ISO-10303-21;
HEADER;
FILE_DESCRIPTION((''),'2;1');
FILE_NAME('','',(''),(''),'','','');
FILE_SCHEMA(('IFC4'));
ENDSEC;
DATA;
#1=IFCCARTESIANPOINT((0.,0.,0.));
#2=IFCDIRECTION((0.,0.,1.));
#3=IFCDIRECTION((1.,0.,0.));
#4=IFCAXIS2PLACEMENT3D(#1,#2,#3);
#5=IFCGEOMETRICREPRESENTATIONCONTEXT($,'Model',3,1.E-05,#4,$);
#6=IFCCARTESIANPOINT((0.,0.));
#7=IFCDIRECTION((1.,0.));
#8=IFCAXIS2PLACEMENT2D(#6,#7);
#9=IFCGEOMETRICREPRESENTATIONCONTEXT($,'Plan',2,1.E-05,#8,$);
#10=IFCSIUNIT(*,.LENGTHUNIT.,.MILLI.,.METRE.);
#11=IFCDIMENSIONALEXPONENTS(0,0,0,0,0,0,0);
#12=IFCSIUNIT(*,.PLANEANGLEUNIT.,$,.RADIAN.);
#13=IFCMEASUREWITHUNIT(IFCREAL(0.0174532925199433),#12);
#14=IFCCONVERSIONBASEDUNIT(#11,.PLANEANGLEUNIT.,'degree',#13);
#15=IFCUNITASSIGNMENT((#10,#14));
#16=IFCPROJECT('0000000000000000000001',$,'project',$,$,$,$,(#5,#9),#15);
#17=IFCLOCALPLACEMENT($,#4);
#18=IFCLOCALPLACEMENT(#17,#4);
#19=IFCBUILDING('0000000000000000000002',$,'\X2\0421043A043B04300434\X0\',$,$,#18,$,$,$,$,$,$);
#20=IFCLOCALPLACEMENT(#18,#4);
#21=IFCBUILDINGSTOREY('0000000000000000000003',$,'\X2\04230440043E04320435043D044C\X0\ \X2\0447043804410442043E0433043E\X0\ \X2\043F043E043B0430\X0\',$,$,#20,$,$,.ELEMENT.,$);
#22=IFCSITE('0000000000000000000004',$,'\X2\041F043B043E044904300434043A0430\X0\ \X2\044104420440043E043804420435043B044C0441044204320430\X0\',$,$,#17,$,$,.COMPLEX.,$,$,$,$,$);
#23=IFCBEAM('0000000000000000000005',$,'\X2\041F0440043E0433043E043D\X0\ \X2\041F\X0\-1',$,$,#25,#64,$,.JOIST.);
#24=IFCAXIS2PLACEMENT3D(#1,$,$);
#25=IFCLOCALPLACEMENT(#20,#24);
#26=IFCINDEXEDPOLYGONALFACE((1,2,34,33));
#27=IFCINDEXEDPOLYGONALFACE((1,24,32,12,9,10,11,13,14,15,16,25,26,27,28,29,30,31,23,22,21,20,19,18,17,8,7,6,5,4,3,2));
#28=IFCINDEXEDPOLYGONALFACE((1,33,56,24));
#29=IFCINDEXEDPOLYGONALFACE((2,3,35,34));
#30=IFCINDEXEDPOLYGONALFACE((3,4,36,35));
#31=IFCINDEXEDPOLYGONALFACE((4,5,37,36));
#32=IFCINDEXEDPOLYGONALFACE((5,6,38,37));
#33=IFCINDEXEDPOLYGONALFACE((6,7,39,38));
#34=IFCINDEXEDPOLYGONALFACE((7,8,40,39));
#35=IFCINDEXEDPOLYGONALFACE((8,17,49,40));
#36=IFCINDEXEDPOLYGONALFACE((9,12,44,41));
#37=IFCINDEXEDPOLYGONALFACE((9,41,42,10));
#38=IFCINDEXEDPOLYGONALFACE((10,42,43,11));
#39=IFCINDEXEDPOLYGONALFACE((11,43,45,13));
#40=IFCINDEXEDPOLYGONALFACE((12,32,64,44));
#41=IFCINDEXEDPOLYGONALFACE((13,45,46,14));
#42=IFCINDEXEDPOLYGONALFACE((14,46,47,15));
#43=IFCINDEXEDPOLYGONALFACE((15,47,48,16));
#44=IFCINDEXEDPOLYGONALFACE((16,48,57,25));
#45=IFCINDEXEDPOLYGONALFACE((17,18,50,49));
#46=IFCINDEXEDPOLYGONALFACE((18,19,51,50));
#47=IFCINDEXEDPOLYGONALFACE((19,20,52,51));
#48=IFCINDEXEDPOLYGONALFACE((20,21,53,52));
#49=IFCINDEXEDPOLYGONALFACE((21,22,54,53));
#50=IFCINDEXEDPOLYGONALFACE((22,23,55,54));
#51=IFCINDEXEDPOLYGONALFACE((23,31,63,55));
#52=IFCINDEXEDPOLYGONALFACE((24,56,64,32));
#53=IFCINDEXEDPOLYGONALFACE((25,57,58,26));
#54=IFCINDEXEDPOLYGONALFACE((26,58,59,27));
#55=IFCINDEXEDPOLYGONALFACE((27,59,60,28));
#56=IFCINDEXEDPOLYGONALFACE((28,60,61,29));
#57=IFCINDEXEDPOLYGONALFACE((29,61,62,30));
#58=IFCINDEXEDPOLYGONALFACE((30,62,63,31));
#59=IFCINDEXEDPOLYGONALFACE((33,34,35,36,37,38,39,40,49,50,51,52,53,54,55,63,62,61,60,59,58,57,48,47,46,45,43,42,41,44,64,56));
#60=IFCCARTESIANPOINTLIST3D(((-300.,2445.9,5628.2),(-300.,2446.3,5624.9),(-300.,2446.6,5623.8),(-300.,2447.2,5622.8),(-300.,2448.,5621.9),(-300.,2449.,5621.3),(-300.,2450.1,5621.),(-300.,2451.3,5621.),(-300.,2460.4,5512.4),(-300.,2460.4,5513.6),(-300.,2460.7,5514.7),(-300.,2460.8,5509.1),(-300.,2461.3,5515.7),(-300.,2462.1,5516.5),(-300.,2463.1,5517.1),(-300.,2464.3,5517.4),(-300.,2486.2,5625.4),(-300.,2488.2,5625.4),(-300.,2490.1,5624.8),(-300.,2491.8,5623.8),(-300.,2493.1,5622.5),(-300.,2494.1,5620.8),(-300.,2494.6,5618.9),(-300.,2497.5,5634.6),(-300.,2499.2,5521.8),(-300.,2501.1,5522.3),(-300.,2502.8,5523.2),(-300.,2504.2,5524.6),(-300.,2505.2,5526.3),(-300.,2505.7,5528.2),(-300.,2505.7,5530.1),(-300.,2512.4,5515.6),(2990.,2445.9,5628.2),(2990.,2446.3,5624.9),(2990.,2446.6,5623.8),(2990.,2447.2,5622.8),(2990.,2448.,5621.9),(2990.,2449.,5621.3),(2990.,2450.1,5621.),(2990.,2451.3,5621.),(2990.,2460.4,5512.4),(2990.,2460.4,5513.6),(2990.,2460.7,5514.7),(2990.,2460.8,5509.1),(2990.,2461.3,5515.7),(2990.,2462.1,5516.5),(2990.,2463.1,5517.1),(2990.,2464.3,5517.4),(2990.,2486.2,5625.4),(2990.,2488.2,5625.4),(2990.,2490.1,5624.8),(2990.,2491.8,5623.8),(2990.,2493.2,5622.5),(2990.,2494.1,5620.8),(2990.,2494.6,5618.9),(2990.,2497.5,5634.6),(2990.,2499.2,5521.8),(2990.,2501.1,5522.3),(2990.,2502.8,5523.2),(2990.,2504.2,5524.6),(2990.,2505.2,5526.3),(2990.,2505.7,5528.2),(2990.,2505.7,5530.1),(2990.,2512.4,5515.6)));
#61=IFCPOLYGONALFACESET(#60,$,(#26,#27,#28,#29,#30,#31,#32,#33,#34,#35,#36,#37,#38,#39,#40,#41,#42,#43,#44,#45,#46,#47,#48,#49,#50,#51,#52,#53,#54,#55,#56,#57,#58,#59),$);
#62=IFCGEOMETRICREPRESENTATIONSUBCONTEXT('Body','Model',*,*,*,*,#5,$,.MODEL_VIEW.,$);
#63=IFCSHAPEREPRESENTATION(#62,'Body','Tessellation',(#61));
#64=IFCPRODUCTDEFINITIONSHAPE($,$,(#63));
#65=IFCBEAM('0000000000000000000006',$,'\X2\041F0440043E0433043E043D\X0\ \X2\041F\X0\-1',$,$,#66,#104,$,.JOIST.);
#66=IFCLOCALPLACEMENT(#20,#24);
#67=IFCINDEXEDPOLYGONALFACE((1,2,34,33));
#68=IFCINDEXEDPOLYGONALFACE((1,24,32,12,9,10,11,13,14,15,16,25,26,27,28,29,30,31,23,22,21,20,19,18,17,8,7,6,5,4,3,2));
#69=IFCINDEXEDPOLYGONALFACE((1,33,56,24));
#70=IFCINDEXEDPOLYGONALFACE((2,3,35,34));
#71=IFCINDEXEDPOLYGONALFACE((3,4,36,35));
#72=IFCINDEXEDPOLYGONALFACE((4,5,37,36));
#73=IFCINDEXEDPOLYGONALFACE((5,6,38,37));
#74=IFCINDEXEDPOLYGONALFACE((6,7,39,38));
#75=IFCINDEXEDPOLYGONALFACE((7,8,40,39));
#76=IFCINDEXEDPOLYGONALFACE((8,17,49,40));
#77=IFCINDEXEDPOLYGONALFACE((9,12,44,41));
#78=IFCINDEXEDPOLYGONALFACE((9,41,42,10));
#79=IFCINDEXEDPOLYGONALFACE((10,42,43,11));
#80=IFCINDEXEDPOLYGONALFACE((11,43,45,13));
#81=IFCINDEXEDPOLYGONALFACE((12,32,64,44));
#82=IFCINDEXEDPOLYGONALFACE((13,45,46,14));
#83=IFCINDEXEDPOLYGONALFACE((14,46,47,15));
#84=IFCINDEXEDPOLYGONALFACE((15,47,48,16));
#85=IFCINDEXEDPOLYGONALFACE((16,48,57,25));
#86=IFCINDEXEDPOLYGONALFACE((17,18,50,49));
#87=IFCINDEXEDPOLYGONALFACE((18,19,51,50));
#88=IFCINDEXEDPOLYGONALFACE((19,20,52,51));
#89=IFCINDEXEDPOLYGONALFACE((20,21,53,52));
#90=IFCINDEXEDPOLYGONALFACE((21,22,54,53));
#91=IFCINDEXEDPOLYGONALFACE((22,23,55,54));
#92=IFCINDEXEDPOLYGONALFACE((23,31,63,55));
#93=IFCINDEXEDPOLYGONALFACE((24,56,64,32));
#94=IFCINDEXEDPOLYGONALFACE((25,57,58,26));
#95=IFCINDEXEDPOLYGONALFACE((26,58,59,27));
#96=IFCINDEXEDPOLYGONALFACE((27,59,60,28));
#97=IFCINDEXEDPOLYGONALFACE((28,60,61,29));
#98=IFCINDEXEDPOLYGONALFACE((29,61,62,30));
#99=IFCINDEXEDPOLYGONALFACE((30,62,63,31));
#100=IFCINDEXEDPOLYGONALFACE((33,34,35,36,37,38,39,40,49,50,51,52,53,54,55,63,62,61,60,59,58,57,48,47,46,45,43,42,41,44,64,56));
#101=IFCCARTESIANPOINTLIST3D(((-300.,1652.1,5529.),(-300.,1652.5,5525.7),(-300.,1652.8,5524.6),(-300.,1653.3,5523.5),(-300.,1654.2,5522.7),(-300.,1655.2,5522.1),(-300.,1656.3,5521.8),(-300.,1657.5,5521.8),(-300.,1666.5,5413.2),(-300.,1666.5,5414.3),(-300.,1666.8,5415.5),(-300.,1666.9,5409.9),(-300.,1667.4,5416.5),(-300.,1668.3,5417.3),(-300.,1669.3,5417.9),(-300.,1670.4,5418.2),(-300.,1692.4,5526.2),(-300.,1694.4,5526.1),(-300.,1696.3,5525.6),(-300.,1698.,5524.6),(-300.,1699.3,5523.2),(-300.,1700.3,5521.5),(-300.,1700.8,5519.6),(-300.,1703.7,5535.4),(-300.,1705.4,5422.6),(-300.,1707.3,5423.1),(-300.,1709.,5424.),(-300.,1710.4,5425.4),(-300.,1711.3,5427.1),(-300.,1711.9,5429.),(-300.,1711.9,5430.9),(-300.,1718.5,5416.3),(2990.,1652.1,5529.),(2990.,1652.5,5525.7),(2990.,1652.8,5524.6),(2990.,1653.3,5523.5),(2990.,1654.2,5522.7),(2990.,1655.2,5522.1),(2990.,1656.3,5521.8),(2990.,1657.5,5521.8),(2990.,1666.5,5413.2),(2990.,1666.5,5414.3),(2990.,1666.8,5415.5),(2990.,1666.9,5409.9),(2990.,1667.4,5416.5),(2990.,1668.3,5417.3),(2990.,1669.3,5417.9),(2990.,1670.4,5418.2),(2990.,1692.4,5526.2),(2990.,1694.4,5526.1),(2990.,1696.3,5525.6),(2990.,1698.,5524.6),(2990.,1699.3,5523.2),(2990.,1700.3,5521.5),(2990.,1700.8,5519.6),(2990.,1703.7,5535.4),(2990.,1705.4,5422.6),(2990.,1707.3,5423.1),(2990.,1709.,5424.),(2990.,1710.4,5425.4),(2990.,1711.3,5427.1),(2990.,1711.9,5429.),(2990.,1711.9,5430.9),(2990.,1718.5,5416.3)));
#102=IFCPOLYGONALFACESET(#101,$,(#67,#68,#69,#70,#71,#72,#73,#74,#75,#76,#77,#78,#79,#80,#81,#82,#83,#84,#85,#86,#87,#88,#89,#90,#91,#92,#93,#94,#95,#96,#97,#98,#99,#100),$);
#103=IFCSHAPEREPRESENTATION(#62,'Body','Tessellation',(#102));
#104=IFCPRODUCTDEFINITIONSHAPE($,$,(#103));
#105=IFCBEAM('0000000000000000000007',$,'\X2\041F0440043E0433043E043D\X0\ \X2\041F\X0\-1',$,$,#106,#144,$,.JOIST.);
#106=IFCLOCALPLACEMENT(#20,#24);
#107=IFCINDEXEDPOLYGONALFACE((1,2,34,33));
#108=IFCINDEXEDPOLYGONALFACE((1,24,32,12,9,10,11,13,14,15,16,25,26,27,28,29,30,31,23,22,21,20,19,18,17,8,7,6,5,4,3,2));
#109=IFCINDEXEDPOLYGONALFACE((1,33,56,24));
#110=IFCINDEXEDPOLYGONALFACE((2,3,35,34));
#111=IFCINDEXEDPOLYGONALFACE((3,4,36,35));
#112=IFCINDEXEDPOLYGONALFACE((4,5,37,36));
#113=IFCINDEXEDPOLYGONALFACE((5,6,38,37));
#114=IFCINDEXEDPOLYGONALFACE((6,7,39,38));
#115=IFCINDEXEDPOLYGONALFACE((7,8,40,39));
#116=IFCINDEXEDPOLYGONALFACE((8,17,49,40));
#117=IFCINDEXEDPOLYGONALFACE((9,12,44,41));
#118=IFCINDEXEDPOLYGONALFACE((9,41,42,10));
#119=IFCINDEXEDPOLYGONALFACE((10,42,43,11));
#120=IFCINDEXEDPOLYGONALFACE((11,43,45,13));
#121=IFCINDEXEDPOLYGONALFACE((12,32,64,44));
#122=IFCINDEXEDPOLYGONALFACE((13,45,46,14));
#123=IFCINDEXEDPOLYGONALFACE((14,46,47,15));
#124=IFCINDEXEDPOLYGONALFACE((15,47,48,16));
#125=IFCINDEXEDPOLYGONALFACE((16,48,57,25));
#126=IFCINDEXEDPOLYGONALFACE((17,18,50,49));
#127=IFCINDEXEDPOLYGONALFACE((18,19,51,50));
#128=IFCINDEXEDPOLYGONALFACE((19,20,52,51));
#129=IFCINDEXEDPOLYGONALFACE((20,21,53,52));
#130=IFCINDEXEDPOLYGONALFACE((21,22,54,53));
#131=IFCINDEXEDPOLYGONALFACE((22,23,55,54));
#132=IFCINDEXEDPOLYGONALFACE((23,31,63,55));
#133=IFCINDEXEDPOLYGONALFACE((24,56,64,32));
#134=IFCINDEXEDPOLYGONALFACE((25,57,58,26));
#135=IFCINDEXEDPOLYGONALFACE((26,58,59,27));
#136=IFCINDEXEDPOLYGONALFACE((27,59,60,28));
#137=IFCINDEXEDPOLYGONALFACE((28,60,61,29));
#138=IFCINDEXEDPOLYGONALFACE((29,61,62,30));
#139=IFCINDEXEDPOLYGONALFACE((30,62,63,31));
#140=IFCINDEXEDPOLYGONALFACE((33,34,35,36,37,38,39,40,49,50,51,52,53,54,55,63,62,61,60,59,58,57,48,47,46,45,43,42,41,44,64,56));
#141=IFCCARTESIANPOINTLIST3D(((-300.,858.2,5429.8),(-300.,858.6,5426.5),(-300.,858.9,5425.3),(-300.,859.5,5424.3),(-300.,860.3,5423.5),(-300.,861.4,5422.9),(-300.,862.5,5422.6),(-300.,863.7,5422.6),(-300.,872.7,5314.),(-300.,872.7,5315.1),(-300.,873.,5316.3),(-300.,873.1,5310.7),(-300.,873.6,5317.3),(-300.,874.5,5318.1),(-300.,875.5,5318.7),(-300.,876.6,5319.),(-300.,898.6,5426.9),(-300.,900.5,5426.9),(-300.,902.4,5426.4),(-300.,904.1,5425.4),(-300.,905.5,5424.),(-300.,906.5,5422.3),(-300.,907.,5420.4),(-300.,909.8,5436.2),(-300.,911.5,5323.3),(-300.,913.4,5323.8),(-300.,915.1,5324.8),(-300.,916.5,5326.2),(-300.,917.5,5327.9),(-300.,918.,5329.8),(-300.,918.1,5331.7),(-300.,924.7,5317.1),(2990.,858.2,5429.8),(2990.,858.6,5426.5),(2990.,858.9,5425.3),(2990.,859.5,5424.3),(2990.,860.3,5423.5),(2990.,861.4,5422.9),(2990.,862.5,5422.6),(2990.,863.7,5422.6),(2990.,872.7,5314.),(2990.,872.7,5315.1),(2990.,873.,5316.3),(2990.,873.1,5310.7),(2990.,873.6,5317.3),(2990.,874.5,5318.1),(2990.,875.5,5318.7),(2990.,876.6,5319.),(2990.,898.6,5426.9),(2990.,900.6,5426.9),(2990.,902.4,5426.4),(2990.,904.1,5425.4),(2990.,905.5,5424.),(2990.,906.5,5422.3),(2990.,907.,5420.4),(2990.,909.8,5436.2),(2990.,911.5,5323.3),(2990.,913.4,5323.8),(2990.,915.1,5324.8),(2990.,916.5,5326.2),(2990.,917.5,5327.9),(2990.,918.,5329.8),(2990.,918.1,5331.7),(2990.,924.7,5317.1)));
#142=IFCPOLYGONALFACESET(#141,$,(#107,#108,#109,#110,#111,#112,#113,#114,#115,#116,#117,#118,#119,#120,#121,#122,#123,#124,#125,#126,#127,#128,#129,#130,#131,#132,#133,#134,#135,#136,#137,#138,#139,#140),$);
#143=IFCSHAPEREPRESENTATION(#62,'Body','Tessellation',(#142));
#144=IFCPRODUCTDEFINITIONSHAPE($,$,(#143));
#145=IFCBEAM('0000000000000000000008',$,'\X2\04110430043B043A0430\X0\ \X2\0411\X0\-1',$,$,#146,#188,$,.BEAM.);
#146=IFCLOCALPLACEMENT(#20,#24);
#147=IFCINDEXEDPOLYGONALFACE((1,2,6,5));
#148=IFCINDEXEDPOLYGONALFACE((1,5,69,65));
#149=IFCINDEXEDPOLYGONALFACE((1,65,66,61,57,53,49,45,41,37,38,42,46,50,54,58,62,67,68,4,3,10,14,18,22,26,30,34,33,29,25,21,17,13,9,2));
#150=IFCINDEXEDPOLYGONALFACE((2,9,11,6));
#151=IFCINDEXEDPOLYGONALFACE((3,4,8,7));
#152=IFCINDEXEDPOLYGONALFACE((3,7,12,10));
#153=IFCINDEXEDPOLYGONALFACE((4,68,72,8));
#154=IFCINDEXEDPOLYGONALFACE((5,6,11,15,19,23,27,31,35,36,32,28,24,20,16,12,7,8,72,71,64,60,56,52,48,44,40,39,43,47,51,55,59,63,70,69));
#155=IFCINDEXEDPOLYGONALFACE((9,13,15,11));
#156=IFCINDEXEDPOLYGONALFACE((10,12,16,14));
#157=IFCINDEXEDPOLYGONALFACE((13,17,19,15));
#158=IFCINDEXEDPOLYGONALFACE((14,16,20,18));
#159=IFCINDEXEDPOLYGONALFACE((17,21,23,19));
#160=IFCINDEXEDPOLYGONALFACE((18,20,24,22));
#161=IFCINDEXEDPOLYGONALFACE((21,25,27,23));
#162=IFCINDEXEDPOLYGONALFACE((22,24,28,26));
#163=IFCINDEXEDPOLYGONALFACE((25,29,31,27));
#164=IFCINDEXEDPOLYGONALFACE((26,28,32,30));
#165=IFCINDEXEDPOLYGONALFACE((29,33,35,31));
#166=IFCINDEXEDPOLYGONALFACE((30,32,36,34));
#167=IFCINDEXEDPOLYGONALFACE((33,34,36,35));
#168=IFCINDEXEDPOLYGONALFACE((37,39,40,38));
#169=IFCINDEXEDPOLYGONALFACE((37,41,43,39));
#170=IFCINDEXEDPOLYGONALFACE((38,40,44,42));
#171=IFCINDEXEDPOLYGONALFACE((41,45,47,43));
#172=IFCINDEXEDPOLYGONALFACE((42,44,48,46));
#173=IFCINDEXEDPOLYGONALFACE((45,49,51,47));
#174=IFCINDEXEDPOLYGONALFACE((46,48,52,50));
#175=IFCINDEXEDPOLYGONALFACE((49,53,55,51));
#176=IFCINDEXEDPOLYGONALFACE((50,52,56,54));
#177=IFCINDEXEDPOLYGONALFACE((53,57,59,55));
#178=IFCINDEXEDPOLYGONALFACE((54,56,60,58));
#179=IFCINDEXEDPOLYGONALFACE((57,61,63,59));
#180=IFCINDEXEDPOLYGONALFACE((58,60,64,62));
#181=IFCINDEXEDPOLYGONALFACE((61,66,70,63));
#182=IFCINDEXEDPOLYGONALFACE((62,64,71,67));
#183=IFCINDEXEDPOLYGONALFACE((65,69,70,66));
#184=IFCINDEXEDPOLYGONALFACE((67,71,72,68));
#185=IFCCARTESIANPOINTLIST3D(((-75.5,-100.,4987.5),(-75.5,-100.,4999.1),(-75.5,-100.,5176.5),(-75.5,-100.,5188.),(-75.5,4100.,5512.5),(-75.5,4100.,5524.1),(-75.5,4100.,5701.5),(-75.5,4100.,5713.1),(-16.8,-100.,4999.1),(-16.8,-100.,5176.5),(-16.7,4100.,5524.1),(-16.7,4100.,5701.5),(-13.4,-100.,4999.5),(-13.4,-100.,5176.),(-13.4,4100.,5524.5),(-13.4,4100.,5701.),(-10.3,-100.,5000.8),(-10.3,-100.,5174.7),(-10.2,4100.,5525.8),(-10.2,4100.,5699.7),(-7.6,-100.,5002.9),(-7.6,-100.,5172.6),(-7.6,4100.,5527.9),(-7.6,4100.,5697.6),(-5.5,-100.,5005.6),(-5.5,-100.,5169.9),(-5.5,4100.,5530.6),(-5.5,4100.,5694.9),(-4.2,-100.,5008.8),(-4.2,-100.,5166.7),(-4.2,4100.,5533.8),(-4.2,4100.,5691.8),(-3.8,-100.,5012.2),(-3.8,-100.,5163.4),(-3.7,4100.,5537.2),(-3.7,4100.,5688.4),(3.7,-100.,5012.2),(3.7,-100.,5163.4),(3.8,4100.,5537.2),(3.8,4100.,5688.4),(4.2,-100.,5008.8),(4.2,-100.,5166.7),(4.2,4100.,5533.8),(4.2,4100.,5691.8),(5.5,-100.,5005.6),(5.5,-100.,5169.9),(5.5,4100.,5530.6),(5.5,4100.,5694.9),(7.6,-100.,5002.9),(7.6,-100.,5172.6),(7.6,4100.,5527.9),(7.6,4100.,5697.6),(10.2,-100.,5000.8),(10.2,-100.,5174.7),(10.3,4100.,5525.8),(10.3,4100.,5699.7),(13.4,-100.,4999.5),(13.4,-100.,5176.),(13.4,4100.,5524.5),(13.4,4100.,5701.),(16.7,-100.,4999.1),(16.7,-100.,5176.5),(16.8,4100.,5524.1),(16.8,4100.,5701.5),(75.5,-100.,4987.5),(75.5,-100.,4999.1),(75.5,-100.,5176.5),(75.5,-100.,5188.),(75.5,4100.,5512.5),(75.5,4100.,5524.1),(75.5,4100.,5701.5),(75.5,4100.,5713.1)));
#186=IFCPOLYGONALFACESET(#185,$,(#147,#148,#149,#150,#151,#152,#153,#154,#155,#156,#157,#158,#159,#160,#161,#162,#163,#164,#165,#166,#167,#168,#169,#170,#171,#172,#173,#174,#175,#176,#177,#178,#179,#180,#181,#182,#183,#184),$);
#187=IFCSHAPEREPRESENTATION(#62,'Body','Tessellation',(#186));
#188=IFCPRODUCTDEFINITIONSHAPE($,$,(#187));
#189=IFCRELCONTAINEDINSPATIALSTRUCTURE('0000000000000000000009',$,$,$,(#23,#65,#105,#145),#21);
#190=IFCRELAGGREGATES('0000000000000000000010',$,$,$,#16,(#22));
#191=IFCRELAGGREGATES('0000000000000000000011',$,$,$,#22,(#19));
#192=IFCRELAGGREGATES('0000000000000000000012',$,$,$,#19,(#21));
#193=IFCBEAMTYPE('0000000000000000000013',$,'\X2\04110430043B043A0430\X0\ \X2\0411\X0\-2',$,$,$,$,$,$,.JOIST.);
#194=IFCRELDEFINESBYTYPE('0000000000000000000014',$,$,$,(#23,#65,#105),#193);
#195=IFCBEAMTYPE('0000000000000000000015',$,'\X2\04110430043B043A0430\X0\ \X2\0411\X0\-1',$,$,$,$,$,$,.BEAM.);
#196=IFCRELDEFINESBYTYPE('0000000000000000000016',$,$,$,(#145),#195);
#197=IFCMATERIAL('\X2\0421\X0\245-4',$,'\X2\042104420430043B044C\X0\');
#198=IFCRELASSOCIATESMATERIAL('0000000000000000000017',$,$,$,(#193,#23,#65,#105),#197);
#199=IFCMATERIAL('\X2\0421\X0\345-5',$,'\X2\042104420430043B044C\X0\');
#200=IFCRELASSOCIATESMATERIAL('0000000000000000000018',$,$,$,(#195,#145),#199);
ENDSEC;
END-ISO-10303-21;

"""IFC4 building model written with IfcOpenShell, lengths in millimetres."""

from ifc_helpers import new_model, entity, si_unit, converted_unit, frame, origin_with_axes, origin_2d_with_axis, place, context, subcontext, project, spatial, i_section, u_section, extrude, clip, halfspace, material, material_profile, profile_set, profile_usage, type_object, element, save


model = new_model("IFC4")

# Units and contexts
model_context = context("Model", 3, precision=1e-05, world=origin_with_axes())
plan_context = context("Plan", 2, precision=1e-05, world=origin_2d_with_axis())
body_context = subcontext(model_context, "Body", "Model", "MODEL_VIEW")
ifc_project = project(units=[si_unit("LENGTHUNIT", "METRE", prefix="MILLI"), converted_unit("PLANEANGLEUNIT", "degree", entity("IfcReal", 0.0174532925199433), si_unit("PLANEANGLEUNIT", "RADIAN"), dimensions=[0, 0, 0, 0, 0, 0, 0])], contexts=[model_context, plan_context])

# Site, building, storey
site_placement = place(None, origin_with_axes())
site = spatial("IfcSite", under=ifc_project, at=site_placement, Name="Площадка строительства", CompositionType="COMPLEX")
building_placement = place(site_placement, origin_with_axes())
building = spatial("IfcBuilding", under=site, at=building_placement, Name="Склад")
storey_placement = place(building_placement, origin_with_axes())
storey = spatial("IfcBuildingStorey", under=building, at=storey_placement, Name="Уровень чистого пола", CompositionType="ELEMENT")

# Shared definitions
ifc_material_1 = material(Name="С345-5", Category="Сталь")

# Beams
ifc_material_2 = material(Name="С245-4", Category="Сталь")
ifc_material_profile_1 = material_profile(ifc_material_2, u_section(Depth=120.0, FlangeWidth=52.0, WebThickness=4.8, FlangeThickness=7.8, FilletRadius=7.5, EdgeRadius=4.5, FlangeSlope=0.0))
ifc_profile_set_1 = profile_set([ifc_material_profile_1], Name="U12P_S245-4")
beam_type_1 = type_object("IfcBeamType", Name="Балка Б-2", PredefinedType="JOIST", material=ifc_profile_set_1)
ifc_profile_usage_1 = profile_usage(ifc_profile_set_1, cardinal=3)
beam_1_placement = place(storey_placement, frame((2990.0, 2512.4, 5515.6), z_axis=(-1.0, 0.0, 0.0), x_axis=(0.0, -0.99228, -0.124019)))
element("IfcBeam", 1, at=beam_1_placement, inside=storey, type_object=beam_type_1, material=ifc_profile_usage_1, Name="Прогон П-1", PredefinedType="JOIST", context=body_context, shape_type="SweptSolid", body=[
    extrude(u_section(Depth=120.0, FlangeWidth=52.0, WebThickness=4.8, FlangeThickness=7.8, FilletRadius=7.5, EdgeRadius=4.5, FlangeSlope=0.0), frame((26.0, 60.0, 0.0), z_axis=(0.0, 0.0, 1.0), x_axis=(1.0, 0.0, 0.0)), (0.0, 0.0, 1.0), 3290.0),
])
ifc_profile_usage_2 = profile_usage(ifc_profile_set_1, cardinal=3)
beam_2_placement = place(storey_placement, frame((2990.0, 1718.5, 5416.3), z_axis=(-1.0, 0.0, 0.0), x_axis=(0.0, -0.99228, -0.124019)))
element("IfcBeam", 2, at=beam_2_placement, inside=storey, type_object=beam_type_1, material=ifc_profile_usage_2, Name="Прогон П-1", PredefinedType="JOIST", context=body_context, shape_type="SweptSolid", body=[
    extrude(u_section(Depth=120.0, FlangeWidth=52.0, WebThickness=4.8, FlangeThickness=7.8, FilletRadius=7.5, EdgeRadius=4.5, FlangeSlope=0.0), frame((26.0, 60.0, 0.0), z_axis=(0.0, 0.0, 1.0), x_axis=(1.0, 0.0, 0.0)), (0.0, 0.0, 1.0), 3290.0),
])
ifc_profile_usage_3 = profile_usage(ifc_profile_set_1, cardinal=3)
beam_3_placement = place(storey_placement, frame((2990.0, 924.7, 5317.1), z_axis=(-1.0, 0.0, 0.0), x_axis=(0.0, -0.99228, -0.124019)))
element("IfcBeam", 3, at=beam_3_placement, inside=storey, type_object=beam_type_1, material=ifc_profile_usage_3, Name="Прогон П-1", PredefinedType="JOIST", context=body_context, shape_type="SweptSolid", body=[
    extrude(u_section(Depth=120.0, FlangeWidth=52.0, WebThickness=4.8, FlangeThickness=7.8, FilletRadius=7.5, EdgeRadius=4.5, FlangeSlope=0.0), frame((26.0, 60.0, 0.0), z_axis=(0.0, 0.0, 1.0), x_axis=(1.0, 0.0, 0.0)), (0.0, 0.0, 1.0), 3290.0),
])
ifc_material_profile_2 = material_profile(ifc_material_1, i_section(OverallWidth=151.0, OverallDepth=199.0, WebThickness=7.5, FlangeThickness=11.5, FilletRadius=13.0, FlangeEdgeRadius=0.0, FlangeSlope=0.0))
ifc_profile_set_2 = profile_set([ifc_material_profile_2], Name="I20H2_S345-5")
ifc_profile_usage_4 = profile_usage(ifc_profile_set_2, cardinal=2)
beam_type_2 = type_object("IfcBeamType", Name="Балка Б-1", PredefinedType="BEAM", material=ifc_profile_set_2)
beam_4_placement = place(storey_placement, frame((0.0, -298.5, 4962.7), z_axis=(0.0, 0.992278, 0.124035), x_axis=(-1.0, 0.0, 0.0)))
element("IfcBeam", 4, at=beam_4_placement, inside=storey, type_object=beam_type_2, material=ifc_profile_usage_4, Name="Балка Б-1", PredefinedType="BEAM", context=body_context, shape_type="Clipping", body=[
    clip(clip(extrude(i_section(OverallWidth=151.0, OverallDepth=199.0, WebThickness=7.5, FlangeThickness=11.5, FilletRadius=13.0, FlangeEdgeRadius=0.0, FlangeSlope=0.0), frame((0.0, 99.5, 0.0), z_axis=(0.0, 0.0, 1.0), x_axis=(1.0, 0.0, 0.0)), (0.0, 0.0, 1.0), 4632.7), halfspace(frame((0.0, -5469.9, 3748.9), z_axis=(0.0, -0.124035, 0.992278), x_axis=(0.0, 0.992278, 0.124035)), False)), halfspace(frame((0.0, -4949.0, -418.6), z_axis=(0.0, 0.124035, -0.992278), x_axis=(0.0, 0.992278, 0.124035)), False)),
])

save(model, "model.ifc")
